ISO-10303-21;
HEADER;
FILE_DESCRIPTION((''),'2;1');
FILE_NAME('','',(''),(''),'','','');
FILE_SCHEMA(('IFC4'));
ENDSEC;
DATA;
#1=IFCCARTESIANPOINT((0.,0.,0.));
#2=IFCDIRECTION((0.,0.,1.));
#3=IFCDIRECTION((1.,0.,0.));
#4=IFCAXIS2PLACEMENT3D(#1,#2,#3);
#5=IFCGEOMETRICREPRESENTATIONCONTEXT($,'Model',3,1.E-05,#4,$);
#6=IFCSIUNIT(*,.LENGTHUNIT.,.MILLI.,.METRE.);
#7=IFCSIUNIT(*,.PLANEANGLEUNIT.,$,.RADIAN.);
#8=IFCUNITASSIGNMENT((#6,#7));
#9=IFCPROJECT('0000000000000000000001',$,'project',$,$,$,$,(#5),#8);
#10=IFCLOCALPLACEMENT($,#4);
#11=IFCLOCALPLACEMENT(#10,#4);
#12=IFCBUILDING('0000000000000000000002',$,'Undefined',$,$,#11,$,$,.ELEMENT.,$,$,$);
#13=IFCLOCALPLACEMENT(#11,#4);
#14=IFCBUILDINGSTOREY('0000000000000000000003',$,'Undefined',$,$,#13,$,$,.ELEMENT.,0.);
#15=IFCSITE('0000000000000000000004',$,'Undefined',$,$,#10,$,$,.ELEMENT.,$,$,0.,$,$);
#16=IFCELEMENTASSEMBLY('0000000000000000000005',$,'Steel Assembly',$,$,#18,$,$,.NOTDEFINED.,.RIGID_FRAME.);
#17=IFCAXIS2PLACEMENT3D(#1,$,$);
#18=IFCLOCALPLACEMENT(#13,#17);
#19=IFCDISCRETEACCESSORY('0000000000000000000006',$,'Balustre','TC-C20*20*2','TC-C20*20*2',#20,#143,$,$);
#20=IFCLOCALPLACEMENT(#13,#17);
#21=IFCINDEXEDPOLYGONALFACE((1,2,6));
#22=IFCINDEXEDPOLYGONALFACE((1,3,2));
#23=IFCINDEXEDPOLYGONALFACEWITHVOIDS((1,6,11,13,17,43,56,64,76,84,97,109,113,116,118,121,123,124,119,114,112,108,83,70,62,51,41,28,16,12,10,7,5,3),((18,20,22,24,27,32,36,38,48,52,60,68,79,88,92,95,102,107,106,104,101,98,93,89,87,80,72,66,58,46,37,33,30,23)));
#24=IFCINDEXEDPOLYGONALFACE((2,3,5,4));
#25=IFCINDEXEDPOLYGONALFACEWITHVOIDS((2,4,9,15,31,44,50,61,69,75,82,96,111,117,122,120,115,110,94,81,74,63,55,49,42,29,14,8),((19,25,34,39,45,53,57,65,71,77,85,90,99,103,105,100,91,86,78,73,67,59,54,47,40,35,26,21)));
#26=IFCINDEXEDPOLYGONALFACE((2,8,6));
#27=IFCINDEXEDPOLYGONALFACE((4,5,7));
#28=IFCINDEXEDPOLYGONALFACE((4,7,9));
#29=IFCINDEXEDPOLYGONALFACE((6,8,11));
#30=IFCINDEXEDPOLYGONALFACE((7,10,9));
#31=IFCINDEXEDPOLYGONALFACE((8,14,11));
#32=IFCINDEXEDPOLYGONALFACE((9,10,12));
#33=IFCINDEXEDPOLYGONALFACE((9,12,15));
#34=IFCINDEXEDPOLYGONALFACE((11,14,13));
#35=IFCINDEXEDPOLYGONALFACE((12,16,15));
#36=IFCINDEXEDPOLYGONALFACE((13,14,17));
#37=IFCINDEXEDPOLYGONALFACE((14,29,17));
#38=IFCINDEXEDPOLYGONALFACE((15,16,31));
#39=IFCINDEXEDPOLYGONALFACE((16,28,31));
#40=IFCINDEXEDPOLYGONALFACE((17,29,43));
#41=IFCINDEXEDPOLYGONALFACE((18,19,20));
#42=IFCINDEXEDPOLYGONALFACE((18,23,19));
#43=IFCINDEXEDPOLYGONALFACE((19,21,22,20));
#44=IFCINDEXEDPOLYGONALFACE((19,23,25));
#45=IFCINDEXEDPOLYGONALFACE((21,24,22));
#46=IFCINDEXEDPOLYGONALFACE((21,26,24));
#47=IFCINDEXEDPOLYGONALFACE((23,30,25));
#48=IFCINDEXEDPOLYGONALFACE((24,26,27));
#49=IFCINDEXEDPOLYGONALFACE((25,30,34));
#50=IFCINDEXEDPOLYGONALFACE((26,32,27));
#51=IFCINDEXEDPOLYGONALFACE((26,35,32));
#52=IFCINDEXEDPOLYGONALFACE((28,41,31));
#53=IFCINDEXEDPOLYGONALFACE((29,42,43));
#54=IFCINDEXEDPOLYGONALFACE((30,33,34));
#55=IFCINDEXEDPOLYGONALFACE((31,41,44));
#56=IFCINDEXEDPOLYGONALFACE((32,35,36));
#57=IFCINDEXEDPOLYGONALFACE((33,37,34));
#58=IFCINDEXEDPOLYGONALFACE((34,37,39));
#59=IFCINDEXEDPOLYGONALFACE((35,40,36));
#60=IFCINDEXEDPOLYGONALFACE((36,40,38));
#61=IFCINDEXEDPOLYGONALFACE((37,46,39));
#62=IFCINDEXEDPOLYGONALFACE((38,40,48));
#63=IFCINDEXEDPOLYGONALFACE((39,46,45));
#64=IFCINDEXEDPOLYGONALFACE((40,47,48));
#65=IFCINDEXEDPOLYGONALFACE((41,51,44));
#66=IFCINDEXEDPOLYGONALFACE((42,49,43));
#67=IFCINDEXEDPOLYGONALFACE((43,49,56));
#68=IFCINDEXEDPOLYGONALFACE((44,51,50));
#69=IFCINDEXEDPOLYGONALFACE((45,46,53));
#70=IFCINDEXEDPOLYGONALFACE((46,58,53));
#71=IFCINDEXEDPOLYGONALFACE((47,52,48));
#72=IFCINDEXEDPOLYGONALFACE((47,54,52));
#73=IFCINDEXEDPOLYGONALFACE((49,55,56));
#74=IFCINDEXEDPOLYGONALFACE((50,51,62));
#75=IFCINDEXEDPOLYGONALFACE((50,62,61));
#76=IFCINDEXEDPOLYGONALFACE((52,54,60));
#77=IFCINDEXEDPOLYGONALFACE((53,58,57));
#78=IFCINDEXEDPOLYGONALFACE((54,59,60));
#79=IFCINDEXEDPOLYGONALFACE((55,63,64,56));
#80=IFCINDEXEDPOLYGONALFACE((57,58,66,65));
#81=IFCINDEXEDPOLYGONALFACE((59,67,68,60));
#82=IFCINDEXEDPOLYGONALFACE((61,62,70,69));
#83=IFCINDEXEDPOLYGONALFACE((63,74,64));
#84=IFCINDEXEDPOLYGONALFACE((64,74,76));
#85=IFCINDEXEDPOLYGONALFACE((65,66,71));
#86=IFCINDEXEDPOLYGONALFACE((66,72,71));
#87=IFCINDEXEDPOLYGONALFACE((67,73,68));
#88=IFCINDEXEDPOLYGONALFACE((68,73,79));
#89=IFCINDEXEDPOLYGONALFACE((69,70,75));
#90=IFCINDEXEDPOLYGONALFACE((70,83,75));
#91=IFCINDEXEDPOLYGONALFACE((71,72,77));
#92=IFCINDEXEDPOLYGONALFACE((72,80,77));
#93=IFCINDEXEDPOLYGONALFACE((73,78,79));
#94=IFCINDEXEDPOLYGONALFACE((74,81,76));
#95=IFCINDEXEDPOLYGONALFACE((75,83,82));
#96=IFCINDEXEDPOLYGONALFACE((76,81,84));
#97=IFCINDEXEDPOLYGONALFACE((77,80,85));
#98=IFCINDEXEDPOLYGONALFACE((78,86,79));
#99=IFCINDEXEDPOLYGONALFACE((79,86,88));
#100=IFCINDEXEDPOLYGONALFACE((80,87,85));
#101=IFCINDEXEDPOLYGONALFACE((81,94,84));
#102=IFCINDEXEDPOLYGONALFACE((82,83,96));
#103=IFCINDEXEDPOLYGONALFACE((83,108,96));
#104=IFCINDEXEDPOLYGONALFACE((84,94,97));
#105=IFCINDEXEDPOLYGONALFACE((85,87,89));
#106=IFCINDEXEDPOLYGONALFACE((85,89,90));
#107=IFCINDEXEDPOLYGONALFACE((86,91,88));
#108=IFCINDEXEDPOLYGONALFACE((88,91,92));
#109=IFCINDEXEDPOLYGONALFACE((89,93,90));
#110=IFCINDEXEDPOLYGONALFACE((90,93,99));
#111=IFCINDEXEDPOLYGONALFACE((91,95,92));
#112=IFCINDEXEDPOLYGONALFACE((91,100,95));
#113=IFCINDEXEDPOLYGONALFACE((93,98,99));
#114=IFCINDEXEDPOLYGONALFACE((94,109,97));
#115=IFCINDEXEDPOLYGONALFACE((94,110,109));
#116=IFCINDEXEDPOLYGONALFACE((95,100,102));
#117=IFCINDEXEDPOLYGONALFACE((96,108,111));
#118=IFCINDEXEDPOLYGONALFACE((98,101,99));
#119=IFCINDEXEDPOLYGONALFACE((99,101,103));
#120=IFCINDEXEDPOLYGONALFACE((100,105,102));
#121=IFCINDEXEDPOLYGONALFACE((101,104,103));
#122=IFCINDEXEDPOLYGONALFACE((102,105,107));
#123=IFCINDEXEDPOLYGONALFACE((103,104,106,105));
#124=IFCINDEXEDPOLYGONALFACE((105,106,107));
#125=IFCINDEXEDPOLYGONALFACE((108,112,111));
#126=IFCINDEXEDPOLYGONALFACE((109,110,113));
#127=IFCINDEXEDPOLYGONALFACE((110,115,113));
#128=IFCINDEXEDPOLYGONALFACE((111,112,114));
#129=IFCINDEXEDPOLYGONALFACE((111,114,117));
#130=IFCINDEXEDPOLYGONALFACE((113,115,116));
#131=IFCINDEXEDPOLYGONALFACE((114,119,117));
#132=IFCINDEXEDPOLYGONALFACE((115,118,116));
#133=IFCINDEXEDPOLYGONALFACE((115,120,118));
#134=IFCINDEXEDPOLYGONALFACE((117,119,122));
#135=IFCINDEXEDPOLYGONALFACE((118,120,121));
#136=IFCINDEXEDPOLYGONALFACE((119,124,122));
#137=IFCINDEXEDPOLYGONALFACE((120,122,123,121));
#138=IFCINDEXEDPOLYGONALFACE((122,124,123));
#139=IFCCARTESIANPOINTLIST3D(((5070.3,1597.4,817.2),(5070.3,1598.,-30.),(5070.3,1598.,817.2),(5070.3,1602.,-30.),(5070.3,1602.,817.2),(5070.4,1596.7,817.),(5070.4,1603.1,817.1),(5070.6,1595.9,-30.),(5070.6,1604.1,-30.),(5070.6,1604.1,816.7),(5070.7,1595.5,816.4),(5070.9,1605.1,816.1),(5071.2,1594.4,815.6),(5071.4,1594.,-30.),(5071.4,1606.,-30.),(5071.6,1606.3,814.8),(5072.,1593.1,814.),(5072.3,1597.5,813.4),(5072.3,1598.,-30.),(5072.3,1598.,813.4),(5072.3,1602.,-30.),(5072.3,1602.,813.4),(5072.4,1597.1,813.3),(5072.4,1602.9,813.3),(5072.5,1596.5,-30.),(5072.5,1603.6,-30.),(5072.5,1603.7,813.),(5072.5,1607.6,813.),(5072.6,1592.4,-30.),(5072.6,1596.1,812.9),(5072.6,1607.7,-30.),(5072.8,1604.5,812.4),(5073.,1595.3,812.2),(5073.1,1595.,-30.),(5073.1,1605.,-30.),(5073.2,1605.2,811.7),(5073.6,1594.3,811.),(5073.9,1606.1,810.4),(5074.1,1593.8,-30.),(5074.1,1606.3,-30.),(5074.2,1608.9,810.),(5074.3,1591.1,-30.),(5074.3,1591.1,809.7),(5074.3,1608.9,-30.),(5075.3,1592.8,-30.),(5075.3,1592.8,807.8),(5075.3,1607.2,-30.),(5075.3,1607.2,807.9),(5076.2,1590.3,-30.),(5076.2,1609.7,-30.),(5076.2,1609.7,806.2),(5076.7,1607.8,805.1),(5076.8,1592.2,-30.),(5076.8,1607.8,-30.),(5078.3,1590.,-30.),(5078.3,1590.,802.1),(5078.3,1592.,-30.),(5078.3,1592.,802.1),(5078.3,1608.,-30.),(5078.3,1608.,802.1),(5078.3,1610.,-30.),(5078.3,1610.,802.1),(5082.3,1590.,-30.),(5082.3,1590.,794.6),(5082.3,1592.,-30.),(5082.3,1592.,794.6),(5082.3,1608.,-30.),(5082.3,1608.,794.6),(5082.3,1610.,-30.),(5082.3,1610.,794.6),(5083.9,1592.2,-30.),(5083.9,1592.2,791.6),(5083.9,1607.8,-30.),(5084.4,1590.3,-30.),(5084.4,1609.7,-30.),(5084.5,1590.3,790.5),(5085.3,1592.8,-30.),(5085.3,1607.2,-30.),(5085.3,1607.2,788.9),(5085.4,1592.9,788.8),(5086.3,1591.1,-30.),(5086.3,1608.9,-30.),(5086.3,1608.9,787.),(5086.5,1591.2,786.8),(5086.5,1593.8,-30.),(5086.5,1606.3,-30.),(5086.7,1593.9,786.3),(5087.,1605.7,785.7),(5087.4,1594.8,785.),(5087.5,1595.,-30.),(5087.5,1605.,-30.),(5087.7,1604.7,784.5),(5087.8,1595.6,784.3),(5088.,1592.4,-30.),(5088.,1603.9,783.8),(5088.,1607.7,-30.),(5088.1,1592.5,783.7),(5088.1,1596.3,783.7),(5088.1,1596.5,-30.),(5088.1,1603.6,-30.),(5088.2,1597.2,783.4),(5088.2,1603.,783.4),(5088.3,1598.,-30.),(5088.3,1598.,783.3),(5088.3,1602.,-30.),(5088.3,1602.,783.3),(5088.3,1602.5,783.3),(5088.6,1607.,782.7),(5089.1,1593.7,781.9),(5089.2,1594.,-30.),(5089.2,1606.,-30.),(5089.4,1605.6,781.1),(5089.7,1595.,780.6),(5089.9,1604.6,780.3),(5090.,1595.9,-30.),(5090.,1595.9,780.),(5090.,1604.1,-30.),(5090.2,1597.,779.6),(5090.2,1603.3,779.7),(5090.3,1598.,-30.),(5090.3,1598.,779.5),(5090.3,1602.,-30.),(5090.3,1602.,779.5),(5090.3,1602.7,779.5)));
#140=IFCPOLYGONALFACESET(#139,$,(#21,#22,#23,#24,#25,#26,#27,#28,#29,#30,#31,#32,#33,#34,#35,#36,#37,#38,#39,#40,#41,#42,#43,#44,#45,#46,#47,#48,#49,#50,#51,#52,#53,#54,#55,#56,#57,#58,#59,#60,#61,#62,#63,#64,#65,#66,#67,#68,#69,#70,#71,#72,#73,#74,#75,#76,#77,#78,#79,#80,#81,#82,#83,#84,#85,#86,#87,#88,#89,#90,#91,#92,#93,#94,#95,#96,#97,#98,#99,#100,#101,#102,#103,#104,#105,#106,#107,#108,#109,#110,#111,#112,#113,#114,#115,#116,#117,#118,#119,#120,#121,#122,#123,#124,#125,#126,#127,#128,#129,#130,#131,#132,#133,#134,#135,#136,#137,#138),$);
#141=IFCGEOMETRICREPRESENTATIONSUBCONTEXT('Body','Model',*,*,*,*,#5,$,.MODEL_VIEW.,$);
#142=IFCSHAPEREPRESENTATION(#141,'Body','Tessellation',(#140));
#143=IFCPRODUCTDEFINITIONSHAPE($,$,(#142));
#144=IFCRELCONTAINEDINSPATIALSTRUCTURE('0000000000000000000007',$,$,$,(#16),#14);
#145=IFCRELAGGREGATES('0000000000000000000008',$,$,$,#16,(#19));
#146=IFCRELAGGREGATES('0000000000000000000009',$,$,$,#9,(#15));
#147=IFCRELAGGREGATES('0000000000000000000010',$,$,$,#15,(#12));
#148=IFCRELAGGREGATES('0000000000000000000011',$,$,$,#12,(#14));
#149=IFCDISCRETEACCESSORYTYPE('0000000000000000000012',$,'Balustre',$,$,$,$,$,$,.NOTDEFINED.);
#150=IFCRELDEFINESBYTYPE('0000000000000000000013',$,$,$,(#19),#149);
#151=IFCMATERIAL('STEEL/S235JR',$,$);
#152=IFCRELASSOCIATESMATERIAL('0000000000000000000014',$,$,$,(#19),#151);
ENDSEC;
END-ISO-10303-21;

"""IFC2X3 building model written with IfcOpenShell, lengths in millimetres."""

from ifc_helpers import new_model, si_unit, frame, origin_with_axes, origin_2d_with_axis, place, context, subcontext, project, spatial, hollow_rectangle, extrude, clip, halfspace, material, type_object, element, aggregate, save


model = new_model("IFC2X3")

# Units and contexts
model_context = context("Model", 3, precision=1e-05, world=origin_with_axes())
body_context = subcontext(model_context, "Body", "Model", "MODEL_VIEW")
ifc_project = project(units=[si_unit("LENGTHUNIT", "METRE", prefix="MILLI"), si_unit("PLANEANGLEUNIT", "RADIAN")], contexts=[model_context])

# Site, building, storey
site_placement = place(None, origin_with_axes())
site = spatial("IfcSite", under=ifc_project, at=site_placement, Name="Undefined", CompositionType="ELEMENT", RefElevation=0.0)
building_placement = place(site_placement, origin_with_axes())
building = spatial("IfcBuilding", under=site, at=building_placement, Name="Undefined", CompositionType="ELEMENT")
storey_placement = place(building_placement, origin_with_axes())
storey = spatial("IfcBuildingStorey", under=building, at=storey_placement, Name="Undefined", CompositionType="ELEMENT", Elevation=0.0)

# Shared definitions
ifc_material = material(Name="STEEL/S235JR")

# Element assembly, discrete accessory
assembly_1_placement = place(storey_placement, origin_with_axes())
assembly_1 = element("IfcElementAssembly", 1, at=assembly_1_placement, inside=storey, Name="Steel Assembly", AssemblyPlace="NOTDEFINED", PredefinedType="RIGID_FRAME")
discrete_accessory_type_1 = type_object("IfcDiscreteAccessoryType", Name="Balustre")
discrete_accessory_1_placement = place(assembly_1_placement, frame((5080.3, 1600.0, -30.0), z_axis=(0.0, 0.0, 1.0), x_axis=(1.0, 0.0, 0.0)))
discrete_accessory_1 = element("IfcDiscreteAccessory", 2, at=discrete_accessory_1_placement, type_object=discrete_accessory_type_1, material=ifc_material, Name="Balustre", Description="TC-C20*20*2", ObjectType="TC-C20*20*2", context=body_context, shape_type="Clipping", body=[
    clip(extrude(hollow_rectangle(XDim=20.0, YDim=20.0, WallThickness=2.0, InnerFilletRadius=6.0, OuterFilletRadius=8.0, at=origin_2d_with_axis()), frame((0.0, 0.0, 847.4), z_axis=(0.0, 0.0, -1.0), x_axis=(-1.0, -0.000011, 0.0)), (0.0, 0.0, 1.0), 847.4), halfspace(frame((287.9, 0.0, 285.4), z_axis=(-0.883506, -0.000005, -0.46842), x_axis=(-0.000005, 1.0, 0.0)), True)),
])

aggregate(assembly_1, [discrete_accessory_1])

save(model, "model.ifc")
